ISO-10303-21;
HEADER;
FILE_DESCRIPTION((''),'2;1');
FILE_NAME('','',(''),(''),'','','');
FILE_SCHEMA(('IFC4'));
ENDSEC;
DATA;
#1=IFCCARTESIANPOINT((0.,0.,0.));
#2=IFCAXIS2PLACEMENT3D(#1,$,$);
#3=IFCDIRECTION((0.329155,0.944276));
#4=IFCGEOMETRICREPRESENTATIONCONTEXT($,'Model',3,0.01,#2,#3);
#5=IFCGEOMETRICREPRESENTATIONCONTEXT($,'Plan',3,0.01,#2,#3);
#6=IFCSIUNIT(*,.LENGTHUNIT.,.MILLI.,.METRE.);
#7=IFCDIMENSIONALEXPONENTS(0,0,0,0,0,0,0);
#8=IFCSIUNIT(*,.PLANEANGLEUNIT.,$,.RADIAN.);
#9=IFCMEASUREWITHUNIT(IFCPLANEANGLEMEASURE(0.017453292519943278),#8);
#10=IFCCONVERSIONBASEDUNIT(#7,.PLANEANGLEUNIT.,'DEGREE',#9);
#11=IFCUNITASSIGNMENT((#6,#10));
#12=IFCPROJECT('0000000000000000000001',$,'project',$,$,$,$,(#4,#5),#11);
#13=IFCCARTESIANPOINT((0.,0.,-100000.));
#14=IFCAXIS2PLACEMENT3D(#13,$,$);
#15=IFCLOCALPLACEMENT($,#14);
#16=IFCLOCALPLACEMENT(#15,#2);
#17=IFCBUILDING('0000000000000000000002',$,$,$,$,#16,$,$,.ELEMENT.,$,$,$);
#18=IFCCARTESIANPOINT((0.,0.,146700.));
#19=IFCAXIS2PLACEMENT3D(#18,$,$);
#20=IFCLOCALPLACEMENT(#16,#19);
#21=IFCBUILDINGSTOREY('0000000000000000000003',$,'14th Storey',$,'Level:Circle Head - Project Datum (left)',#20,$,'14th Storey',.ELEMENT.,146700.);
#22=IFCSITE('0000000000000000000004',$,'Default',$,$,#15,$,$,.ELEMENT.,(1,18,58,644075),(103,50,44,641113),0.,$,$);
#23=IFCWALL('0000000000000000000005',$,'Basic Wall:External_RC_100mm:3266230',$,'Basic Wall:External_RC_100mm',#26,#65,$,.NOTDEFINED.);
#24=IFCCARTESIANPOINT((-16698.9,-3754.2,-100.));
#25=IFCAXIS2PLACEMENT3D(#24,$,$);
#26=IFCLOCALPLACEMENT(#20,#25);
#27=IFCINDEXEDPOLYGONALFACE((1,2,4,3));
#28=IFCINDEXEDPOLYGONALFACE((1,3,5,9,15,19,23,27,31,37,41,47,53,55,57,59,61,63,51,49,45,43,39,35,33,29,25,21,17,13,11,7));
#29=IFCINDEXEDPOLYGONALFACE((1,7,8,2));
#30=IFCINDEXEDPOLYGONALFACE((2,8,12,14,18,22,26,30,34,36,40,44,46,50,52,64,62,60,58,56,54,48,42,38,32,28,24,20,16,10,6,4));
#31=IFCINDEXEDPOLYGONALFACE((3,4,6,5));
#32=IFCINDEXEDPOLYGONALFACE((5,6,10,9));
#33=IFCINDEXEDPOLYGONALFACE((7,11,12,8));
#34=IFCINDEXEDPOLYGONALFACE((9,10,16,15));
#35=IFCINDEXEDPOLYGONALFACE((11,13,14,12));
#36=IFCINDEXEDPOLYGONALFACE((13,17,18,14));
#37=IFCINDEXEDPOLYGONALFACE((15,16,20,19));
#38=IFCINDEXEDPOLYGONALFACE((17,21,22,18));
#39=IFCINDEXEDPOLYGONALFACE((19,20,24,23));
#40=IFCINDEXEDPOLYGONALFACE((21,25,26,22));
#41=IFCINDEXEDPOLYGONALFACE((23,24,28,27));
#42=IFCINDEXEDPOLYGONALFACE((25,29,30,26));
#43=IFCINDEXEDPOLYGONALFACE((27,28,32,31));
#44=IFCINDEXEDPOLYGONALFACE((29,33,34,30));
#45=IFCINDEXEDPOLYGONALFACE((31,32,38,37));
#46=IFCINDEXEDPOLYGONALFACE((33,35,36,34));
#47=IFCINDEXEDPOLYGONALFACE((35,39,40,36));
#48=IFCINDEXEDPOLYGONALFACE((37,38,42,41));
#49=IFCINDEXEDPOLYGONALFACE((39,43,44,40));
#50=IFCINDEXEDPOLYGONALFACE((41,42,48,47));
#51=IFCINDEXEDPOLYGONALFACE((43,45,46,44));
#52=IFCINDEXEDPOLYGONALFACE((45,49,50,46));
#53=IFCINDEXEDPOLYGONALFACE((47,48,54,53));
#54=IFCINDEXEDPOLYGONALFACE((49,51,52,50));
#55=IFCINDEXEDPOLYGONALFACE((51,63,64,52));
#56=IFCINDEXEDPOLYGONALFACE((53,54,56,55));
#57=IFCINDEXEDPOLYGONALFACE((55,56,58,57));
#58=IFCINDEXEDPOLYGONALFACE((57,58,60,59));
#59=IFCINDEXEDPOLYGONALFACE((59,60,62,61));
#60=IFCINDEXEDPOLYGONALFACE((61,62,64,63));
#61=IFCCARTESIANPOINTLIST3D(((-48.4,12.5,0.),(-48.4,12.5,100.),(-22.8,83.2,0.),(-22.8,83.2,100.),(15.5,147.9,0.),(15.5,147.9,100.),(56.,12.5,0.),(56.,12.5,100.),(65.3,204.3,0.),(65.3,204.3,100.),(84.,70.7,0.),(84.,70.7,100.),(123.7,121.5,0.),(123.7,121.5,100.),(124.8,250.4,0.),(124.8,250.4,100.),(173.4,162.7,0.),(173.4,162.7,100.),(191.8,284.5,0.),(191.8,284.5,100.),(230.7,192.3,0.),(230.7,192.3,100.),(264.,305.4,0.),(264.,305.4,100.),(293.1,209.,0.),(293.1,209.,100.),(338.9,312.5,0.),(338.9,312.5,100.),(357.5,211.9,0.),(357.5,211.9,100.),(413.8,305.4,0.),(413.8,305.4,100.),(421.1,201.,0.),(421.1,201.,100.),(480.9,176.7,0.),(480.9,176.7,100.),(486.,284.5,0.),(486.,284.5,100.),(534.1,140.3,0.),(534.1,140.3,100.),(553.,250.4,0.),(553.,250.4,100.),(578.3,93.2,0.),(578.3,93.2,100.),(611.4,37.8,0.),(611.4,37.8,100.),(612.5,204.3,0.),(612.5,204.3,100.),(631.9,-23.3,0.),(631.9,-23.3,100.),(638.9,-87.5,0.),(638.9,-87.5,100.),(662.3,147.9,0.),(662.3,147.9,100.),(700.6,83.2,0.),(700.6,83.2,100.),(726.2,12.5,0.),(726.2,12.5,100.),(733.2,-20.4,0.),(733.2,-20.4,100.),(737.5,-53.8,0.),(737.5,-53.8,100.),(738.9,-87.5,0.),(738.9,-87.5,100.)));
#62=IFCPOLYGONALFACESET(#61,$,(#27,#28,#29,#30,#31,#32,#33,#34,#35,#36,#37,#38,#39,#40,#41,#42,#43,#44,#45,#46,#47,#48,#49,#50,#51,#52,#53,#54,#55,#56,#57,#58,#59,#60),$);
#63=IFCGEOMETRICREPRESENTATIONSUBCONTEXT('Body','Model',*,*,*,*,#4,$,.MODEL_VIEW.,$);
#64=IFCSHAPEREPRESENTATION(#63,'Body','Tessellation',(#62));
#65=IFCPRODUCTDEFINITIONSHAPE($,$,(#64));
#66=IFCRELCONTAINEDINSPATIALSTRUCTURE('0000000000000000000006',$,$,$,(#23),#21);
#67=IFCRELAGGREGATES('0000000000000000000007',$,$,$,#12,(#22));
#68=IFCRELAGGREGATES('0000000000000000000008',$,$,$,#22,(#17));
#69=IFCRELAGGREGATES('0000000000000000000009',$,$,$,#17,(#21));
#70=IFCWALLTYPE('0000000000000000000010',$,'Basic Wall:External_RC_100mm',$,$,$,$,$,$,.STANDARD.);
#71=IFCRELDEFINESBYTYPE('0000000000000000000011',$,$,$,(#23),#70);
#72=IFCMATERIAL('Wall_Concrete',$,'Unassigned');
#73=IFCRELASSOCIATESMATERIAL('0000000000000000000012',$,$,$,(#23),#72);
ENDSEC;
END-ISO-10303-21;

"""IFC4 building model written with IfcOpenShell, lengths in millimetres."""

from ifc_helpers import new_model, entity, si_unit, converted_unit, direction, frame, origin, place, context, subcontext, project, spatial, line, arc, indexed_curve, outline, extrude, material, type_object, element, save


model = new_model("IFC4")

# Units and contexts
model_context = context("Model", 3, precision=0.01, world=origin(), true_north=direction((0.329155, 0.944276)))
plan_context = context("Plan", 3, precision=0.01, world=origin(), true_north=direction((0.329155, 0.944276)))
body_context = subcontext(model_context, "Body", "Model", "MODEL_VIEW")
ifc_project = project(units=[si_unit("LENGTHUNIT", "METRE", prefix="MILLI"), converted_unit("PLANEANGLEUNIT", "DEGREE", entity("IfcPlaneAngleMeasure", 0.017453292519943278), si_unit("PLANEANGLEUNIT", "RADIAN"), dimensions=[0, 0, 0, 0, 0, 0, 0])], contexts=[model_context, plan_context])

# Site, building, storey
site_placement = place(None, frame((0.0, 0.0, -100000.0)))
site = spatial("IfcSite", under=ifc_project, at=site_placement, Name="Default", CompositionType="ELEMENT", RefLatitude=(1, 18, 58, 644075), RefLongitude=(103, 50, 44, 641113), RefElevation=0.0)
building_placement = place(site_placement, origin())
building = spatial("IfcBuilding", under=site, at=building_placement, CompositionType="ELEMENT")
storey_placement = place(building_placement, frame((0.0, 0.0, 146700.0)))
storey = spatial("IfcBuildingStorey", under=building, at=storey_placement, Name="14th Storey", ObjectType="Level:Circle Head - Project Datum (left)", LongName="14th Storey", CompositionType="ELEMENT", Elevation=146700.0)

# Wall
ifc_material_1 = material(Name="Wall_Concrete", Category="Unassigned")
wall_type_1 = type_object("IfcWallType", Name="Basic Wall:External_RC_100mm", PredefinedType="STANDARD")
wall_1_placement = place(storey_placement, frame((-16698.9, -3754.2, -100.0)))
element("IfcWall", 1, at=wall_1_placement, inside=storey, type_object=wall_type_1, material=ifc_material_1, Name="Basic Wall:External_RC_100mm:3266230", ObjectType="Basic Wall:External_RC_100mm", PredefinedType="NOTDEFINED", context=body_context, shape_type="SweptSolid", body=[
    extrude(outline(indexed_curve([(738.9, -87.5), (735.7, -37.1), (726.2, 12.5), (338.9, 312.5), (-48.4, 12.5), (56.0, 12.5), (389.6, 208.2), (638.9, -87.5)], segments=[arc(1, 2, 3), arc(3, 4, 5), line(5, 6), arc(6, 7, 8), line(8, 1)], self_intersect=False)), origin(), (0.0, 0.0, 1.0), 100.0),
])

save(model, "model.ifc")
